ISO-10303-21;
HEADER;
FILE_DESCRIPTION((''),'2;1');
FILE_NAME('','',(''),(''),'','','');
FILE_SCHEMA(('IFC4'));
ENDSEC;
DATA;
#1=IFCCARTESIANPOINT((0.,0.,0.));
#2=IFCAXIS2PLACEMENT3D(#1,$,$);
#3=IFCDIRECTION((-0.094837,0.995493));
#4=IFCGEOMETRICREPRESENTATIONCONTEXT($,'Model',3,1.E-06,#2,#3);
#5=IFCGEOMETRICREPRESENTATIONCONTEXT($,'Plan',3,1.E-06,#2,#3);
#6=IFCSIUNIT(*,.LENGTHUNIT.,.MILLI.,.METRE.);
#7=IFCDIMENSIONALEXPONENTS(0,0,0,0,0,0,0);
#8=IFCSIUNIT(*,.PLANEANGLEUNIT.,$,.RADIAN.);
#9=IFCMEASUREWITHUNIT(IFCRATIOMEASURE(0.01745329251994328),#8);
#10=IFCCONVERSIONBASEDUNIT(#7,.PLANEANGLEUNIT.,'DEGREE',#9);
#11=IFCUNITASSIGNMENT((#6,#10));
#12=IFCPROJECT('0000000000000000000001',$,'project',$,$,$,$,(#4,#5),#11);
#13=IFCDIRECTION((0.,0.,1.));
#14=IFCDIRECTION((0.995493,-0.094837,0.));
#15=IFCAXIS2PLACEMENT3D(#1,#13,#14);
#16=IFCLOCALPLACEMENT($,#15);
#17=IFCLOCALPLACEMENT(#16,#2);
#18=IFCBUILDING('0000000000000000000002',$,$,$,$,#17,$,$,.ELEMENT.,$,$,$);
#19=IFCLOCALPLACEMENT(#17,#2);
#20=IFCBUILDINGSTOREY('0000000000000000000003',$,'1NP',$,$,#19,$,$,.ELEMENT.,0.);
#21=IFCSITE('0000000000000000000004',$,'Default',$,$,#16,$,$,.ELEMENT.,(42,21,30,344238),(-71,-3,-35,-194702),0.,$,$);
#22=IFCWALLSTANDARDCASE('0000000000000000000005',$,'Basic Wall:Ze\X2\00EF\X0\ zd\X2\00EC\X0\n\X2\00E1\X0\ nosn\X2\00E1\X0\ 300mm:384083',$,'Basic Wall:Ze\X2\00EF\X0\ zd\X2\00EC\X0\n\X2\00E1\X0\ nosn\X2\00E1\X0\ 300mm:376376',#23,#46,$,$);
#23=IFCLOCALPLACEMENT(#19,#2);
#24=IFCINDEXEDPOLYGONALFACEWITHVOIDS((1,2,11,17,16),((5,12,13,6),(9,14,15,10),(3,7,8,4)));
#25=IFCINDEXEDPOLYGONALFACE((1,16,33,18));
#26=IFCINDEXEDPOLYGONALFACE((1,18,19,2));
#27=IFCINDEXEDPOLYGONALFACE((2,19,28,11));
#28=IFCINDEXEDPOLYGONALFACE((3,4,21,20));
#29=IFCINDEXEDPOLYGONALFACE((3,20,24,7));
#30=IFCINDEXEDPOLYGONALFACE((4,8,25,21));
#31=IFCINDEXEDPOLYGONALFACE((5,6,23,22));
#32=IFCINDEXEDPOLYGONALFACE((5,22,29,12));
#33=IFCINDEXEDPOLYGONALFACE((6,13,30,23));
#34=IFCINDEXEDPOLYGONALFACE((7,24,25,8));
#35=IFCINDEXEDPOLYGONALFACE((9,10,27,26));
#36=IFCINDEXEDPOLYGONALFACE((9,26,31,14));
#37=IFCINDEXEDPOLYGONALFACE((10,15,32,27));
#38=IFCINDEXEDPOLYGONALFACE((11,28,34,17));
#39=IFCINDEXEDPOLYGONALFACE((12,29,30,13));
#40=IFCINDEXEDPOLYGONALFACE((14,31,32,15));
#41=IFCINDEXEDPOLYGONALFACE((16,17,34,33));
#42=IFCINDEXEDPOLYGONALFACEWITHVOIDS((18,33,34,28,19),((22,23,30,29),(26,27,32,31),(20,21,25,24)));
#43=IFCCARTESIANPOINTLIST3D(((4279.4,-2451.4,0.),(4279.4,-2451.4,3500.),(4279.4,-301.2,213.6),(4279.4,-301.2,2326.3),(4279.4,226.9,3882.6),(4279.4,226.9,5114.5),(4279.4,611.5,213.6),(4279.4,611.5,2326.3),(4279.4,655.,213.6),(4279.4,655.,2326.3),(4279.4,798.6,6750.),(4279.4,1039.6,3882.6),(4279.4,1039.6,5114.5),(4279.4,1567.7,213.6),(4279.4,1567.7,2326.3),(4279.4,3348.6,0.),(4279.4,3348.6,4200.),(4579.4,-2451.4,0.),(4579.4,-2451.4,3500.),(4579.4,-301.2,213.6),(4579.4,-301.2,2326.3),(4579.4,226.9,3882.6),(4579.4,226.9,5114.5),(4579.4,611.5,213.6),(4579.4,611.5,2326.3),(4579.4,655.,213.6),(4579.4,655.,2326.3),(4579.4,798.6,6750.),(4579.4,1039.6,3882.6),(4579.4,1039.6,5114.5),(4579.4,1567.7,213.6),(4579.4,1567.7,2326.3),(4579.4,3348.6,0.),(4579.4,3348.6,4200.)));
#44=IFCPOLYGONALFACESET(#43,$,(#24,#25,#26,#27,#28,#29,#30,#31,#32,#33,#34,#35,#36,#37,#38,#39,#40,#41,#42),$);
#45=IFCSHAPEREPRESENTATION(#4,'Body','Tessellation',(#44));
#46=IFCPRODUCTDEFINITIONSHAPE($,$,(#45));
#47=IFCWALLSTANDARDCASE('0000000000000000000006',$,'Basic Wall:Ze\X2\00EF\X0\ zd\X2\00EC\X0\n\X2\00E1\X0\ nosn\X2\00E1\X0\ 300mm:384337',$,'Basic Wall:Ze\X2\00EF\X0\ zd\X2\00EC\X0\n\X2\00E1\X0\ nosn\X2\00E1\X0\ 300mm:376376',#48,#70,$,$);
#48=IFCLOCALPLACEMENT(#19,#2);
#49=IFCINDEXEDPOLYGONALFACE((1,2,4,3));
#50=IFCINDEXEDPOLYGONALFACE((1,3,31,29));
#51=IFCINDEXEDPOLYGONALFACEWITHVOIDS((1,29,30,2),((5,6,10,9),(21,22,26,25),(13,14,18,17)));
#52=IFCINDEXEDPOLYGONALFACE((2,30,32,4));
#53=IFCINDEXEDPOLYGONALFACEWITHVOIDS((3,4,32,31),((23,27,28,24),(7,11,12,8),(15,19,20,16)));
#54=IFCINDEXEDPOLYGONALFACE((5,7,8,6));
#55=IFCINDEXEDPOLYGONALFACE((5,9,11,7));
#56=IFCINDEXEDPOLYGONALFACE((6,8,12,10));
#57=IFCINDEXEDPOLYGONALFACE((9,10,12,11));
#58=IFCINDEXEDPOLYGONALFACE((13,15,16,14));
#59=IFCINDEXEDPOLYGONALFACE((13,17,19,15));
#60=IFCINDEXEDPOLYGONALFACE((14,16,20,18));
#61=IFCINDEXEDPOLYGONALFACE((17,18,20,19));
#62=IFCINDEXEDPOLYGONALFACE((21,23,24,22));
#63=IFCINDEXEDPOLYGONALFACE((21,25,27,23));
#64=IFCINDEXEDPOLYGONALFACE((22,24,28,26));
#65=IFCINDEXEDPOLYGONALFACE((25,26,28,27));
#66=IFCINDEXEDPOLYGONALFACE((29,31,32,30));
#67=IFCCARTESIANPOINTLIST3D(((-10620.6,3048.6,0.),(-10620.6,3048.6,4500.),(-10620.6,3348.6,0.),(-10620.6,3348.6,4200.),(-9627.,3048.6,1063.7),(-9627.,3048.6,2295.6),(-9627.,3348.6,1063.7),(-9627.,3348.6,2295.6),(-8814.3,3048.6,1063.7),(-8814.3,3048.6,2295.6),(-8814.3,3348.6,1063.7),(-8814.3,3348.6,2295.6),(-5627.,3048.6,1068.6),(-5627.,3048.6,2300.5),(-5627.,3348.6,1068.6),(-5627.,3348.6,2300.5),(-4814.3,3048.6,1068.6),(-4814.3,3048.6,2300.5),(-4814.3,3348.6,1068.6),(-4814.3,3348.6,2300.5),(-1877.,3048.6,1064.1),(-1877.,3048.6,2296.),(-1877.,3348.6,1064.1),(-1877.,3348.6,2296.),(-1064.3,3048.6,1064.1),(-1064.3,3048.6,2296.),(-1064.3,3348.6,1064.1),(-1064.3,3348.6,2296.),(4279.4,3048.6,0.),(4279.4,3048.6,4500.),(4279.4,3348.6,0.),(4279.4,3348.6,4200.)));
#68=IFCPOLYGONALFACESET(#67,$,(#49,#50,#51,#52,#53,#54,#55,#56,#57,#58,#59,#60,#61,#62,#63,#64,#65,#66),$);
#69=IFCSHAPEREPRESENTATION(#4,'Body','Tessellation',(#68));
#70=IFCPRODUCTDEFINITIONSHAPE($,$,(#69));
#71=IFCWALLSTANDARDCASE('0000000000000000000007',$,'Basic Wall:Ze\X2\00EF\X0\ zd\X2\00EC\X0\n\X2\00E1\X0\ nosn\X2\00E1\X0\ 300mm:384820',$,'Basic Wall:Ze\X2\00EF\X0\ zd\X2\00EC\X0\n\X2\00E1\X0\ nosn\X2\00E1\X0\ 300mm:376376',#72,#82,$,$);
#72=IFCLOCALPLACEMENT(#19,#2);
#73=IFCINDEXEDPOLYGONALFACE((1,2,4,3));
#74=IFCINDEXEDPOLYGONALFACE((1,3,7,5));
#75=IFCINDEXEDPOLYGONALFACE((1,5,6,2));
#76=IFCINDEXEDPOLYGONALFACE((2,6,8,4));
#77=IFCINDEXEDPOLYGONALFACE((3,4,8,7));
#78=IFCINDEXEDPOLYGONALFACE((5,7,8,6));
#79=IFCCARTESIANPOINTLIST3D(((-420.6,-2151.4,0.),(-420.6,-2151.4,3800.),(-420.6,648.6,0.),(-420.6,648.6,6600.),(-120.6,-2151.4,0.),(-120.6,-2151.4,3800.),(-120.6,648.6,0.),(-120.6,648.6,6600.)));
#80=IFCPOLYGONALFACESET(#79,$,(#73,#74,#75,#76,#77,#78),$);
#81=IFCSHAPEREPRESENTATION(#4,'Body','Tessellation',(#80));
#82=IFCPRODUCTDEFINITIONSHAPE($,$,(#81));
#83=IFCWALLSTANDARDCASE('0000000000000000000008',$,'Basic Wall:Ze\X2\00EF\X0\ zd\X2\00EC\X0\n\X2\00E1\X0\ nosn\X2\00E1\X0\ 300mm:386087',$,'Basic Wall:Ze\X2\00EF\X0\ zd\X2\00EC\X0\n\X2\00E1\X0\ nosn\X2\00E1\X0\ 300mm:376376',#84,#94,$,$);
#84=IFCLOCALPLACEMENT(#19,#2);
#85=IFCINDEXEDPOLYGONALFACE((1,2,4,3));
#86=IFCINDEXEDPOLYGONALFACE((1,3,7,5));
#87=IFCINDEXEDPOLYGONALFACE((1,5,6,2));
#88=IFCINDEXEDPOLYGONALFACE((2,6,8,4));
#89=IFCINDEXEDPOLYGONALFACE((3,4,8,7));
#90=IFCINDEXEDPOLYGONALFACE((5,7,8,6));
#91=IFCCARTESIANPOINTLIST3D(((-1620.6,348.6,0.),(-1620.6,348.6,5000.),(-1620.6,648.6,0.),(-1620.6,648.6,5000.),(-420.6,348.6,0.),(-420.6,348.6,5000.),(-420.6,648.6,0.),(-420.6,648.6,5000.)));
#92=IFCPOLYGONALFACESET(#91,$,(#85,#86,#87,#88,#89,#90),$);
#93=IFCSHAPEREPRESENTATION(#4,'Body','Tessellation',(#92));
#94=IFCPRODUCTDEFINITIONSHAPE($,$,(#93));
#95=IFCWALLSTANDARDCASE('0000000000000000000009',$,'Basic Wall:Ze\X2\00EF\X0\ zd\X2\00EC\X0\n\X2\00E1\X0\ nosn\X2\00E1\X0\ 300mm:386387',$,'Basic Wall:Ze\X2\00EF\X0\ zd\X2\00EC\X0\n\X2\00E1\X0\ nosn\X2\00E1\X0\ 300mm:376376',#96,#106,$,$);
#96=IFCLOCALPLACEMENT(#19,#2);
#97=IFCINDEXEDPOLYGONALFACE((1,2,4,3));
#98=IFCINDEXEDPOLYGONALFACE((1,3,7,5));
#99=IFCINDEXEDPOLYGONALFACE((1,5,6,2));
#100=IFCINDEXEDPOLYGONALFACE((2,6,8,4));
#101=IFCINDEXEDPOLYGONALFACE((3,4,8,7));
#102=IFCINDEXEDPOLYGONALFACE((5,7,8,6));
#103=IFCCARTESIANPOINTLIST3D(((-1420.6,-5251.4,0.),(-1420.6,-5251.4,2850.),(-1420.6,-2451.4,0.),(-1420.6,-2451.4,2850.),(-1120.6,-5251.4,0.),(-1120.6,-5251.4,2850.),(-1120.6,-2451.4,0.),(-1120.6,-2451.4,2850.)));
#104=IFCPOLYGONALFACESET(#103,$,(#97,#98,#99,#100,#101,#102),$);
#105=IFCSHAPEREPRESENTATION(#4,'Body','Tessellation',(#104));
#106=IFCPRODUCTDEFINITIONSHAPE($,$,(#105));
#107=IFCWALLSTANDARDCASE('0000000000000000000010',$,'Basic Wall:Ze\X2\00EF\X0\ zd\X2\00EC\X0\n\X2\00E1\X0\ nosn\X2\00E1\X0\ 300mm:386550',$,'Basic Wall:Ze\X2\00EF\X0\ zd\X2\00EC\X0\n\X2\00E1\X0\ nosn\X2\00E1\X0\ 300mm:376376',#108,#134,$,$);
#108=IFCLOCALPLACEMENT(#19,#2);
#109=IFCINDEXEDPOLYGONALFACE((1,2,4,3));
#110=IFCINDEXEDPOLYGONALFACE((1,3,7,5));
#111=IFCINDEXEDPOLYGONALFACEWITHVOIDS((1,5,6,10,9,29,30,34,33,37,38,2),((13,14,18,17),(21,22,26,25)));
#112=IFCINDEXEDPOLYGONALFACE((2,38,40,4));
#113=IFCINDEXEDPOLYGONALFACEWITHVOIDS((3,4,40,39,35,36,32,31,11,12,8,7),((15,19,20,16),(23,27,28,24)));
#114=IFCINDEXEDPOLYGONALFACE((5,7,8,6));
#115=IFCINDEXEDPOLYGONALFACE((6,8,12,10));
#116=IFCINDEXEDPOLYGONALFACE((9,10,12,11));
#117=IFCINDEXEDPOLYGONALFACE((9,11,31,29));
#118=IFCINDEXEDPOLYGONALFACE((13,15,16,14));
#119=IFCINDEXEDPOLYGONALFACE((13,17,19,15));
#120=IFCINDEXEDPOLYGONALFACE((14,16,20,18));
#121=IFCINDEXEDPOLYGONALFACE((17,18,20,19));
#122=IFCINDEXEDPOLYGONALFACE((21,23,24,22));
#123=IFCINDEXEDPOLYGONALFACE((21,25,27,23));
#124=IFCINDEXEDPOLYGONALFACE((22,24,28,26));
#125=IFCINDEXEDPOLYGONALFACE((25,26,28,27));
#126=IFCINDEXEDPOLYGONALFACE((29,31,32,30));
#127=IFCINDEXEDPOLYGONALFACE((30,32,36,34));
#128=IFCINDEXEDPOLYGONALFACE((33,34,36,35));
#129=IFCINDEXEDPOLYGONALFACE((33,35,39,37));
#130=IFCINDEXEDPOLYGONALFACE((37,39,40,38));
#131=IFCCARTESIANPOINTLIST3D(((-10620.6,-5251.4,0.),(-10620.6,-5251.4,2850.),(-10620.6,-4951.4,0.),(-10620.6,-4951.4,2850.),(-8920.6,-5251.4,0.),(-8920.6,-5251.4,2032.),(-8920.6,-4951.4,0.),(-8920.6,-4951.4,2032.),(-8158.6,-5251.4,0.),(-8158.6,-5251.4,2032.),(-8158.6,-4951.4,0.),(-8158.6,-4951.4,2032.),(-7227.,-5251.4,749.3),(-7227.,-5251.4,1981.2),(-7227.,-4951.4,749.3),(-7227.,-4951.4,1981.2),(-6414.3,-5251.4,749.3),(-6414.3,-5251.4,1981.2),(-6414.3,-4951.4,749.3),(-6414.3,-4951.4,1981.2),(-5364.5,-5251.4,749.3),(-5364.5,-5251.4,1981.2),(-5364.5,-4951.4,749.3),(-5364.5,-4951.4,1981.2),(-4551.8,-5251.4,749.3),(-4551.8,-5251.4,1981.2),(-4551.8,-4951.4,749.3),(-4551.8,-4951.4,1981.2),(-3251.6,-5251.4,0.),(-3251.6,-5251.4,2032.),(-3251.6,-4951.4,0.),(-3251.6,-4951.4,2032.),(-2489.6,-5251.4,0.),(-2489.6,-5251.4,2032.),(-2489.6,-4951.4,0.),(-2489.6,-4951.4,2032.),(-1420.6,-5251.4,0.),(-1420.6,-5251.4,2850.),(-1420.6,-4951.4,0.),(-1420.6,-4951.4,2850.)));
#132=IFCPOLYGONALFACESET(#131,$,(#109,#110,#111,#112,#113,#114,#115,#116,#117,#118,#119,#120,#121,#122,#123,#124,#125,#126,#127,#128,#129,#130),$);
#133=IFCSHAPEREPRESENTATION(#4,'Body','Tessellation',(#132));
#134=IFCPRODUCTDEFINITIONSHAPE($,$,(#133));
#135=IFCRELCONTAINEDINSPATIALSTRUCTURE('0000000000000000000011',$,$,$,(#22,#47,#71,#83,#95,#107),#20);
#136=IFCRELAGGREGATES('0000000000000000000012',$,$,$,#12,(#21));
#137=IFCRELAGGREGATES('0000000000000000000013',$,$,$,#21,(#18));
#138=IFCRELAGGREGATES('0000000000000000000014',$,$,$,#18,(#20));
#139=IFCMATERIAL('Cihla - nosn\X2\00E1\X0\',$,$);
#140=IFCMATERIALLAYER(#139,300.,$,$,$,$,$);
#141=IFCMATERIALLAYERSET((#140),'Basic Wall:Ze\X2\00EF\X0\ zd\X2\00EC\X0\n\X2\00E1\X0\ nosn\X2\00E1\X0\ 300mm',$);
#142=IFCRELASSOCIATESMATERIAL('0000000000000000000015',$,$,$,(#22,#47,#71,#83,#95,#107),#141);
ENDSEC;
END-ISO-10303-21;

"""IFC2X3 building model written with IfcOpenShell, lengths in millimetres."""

from ifc_helpers import new_model, entity, si_unit, converted_unit, direction, frame, frame_2d, origin, place, context, project, spatial, polyline, rectangle, extrude, clip, bounded_halfspace, material, layer, layer_set, layer_usage, element, save


model = new_model("IFC2X3")

# Units and contexts
model_context = context("Model", 3, precision=1e-06, world=origin(), true_north=direction((-0.094837, 0.995493)))
plan_context = context("Plan", 3, precision=1e-06, world=origin(), true_north=direction((-0.094837, 0.995493)))
ifc_project = project(units=[si_unit("LENGTHUNIT", "METRE", prefix="MILLI"), converted_unit("PLANEANGLEUNIT", "DEGREE", entity("IfcRatioMeasure", 0.01745329251994328), si_unit("PLANEANGLEUNIT", "RADIAN"), dimensions=[0, 0, 0, 0, 0, 0, 0])], contexts=[model_context, plan_context])

# Site, building, storey
site_placement = place(None, frame((0.0, 0.0, 0.0), z_axis=(0.0, 0.0, 1.0), x_axis=(0.995493, -0.094837, 0.0)))
site = spatial("IfcSite", under=ifc_project, at=site_placement, Name="Default", CompositionType="ELEMENT", RefLatitude=(42, 21, 30, 344238), RefLongitude=(-71, -3, -35, -194702), RefElevation=0.0)
building_placement = place(site_placement, origin())
building = spatial("IfcBuilding", under=site, at=building_placement, CompositionType="ELEMENT")
storey_placement = place(building_placement, origin())
storey = spatial("IfcBuildingStorey", under=building, at=storey_placement, Name="1NP", CompositionType="ELEMENT", Elevation=0.0)

# Walls, openings
ifc_material_1 = material(Name="Cihla - nosná")
ifc_layer_1 = layer(ifc_material_1, 300.0)
ifc_layer_set_1 = layer_set([ifc_layer_1], Name="Basic Wall:Zeï zdìná nosná 300mm")
ifc_layer_usage_1 = layer_usage(ifc_layer_set_1, "AXIS2", "POSITIVE", -150.0)
wall_1_placement = place(storey_placement, frame((4429.4, -2451.4, 0.0), z_axis=(0.0, 0.0, 1.0), x_axis=(0.0, 1.0, 0.0)))
wall_1 = element("IfcWallStandardCase", 1, at=wall_1_placement, inside=storey, material=ifc_layer_usage_1, Name="Basic Wall:Zeï zdìná nosná 300mm:384083", ObjectType="Basic Wall:Zeï zdìná nosná 300mm:376376", context=model_context, shape_type="Clipping", body=[
    clip(clip(extrude(rectangle(XDim=5800.0, YDim=300.0, at=frame_2d((2900.0, 0.0), x_axis=(-1.0, 0.0))), origin(), (0.0, 0.0, 1.0), 6750.0), bounded_halfspace(frame((0.0, -150.0, 3500.0), z_axis=(-0.707107, 0.0, 0.707107), x_axis=(0.0, -1.0, 0.0)), False, frame((0.0, -150.0, 3500.0)), polyline([(0.0, 0.0), (3250.0, 0.0), (3250.0, 300.0), (300.0, 300.0), (0.0, 300.0), (0.0, 0.0)]))), bounded_halfspace(frame((3250.0, -150.0, 6750.0), z_axis=(0.707107, 0.0, 0.707107), x_axis=(0.0, 1.0, 0.0)), False, frame((3250.0, -150.0, 6750.0)), polyline([(0.0, 0.0), (2550.0, 0.0), (2550.0, 300.0), (2250.0, 300.0), (0.0, 300.0), (0.0, 0.0)]))),
])
opening_1_placement = place(wall_1_placement, frame((4019.1, 150.0, 213.6)))
element("IfcOpeningElement", 2, at=opening_1_placement, cuts=wall_1, ObjectType="Opening", context=model_context, shape_type="SweptSolid", body=[
    extrude(rectangle(XDim=2112.7, YDim=912.7, at=frame_2d((1056.3, 456.3), x_axis=(-1.0, 0.0))), frame((0.0, 0.0, 0.0), z_axis=(0.0, -1.0, 0.0), x_axis=(0.0, 0.0, 1.0)), (0.0, 0.0, 1.0), 300.0),
])
opening_2_placement = place(wall_1_placement, frame((3062.9, 150.0, 213.6)))
element("IfcOpeningElement", 3, at=opening_2_placement, cuts=wall_1, ObjectType="Opening", context=model_context, shape_type="SweptSolid", body=[
    extrude(rectangle(XDim=2112.7, YDim=912.7, at=frame_2d((1056.3, 456.3), x_axis=(-1.0, 0.0))), frame((0.0, 0.0, 0.0), z_axis=(0.0, -1.0, 0.0), x_axis=(0.0, 0.0, 1.0)), (0.0, 0.0, 1.0), 300.0),
])
opening_3_placement = place(wall_1_placement, frame((3491.0, 150.0, 3882.6)))
element("IfcOpeningElement", 4, at=opening_3_placement, cuts=wall_1, ObjectType="Opening", context=model_context, shape_type="SweptSolid", body=[
    extrude(rectangle(XDim=1231.9, YDim=812.7, at=frame_2d((615.9, 406.4), x_axis=(-1.0, 0.0))), frame((0.0, 0.0, 0.0), z_axis=(0.0, -1.0, 0.0), x_axis=(0.0, 0.0, 1.0)), (0.0, 0.0, 1.0), 300.0),
])
ifc_layer_usage_2 = layer_usage(ifc_layer_set_1, "AXIS2", "POSITIVE", -150.0)
wall_2_placement = place(storey_placement, frame((4279.4, 3198.6, 0.0), z_axis=(0.0, 0.0, 1.0), x_axis=(-1.0, 0.0, 0.0)))
wall_2 = element("IfcWallStandardCase", 5, at=wall_2_placement, inside=storey, material=ifc_layer_usage_2, Name="Basic Wall:Zeï zdìná nosná 300mm:384337", ObjectType="Basic Wall:Zeï zdìná nosná 300mm:376376", context=model_context, shape_type="Clipping", body=[
    clip(extrude(rectangle(XDim=14900.0, YDim=300.0, at=frame_2d((7450.0, 0.0), x_axis=(-1.0, 0.0))), origin(), (0.0, 0.0, 1.0), 4500.0), bounded_halfspace(frame((0.0, -150.0, 4200.0), z_axis=(0.0, -0.707107, 0.707107), x_axis=(1.0, 0.0, 0.0)), False, frame((0.0, -150.0, 4200.0)), polyline([(0.0, 0.0), (14900.0, 0.0), (14900.0, 300.0), (14600.0, 300.0), (0.0, 300.0), (0.0, 0.0)]))),
])
opening_4_placement = place(wall_2_placement, frame((6156.4, 150.0, 1064.1)))
element("IfcOpeningElement", 6, at=opening_4_placement, cuts=wall_2, ObjectType="Opening", context=model_context, shape_type="SweptSolid", body=[
    extrude(rectangle(XDim=1231.9, YDim=812.7, at=frame_2d((615.9, 406.4), x_axis=(-1.0, 0.0))), frame((0.0, 0.0, 0.0), z_axis=(0.0, -1.0, 0.0), x_axis=(0.0, 0.0, 1.0)), (0.0, 0.0, 1.0), 300.0),
])
opening_5_placement = place(wall_2_placement, frame((9906.4, 150.0, 1068.6)))
element("IfcOpeningElement", 7, at=opening_5_placement, cuts=wall_2, ObjectType="Opening", context=model_context, shape_type="SweptSolid", body=[
    extrude(rectangle(XDim=1231.9, YDim=812.7, at=frame_2d((615.9, 406.3), x_axis=(-1.0, 0.0))), frame((0.0, 0.0, 0.0), z_axis=(0.0, -1.0, 0.0), x_axis=(0.0, 0.0, 1.0)), (0.0, 0.0, 1.0), 300.0),
])
opening_6_placement = place(wall_2_placement, frame((13906.4, 150.0, 1063.7)))
element("IfcOpeningElement", 8, at=opening_6_placement, cuts=wall_2, ObjectType="Opening", context=model_context, shape_type="SweptSolid", body=[
    extrude(rectangle(XDim=1231.9, YDim=812.7, at=frame_2d((615.9, 406.3), x_axis=(-1.0, 0.0))), frame((0.0, 0.0, 0.0), z_axis=(0.0, -1.0, 0.0), x_axis=(0.0, 0.0, 1.0)), (0.0, 0.0, 1.0), 300.0),
])

# Walls
ifc_layer_usage_3 = layer_usage(ifc_layer_set_1, "AXIS2", "POSITIVE", -150.0)
wall_3_placement = place(storey_placement, frame((-270.6, -2151.4, 0.0), z_axis=(0.0, 0.0, 1.0), x_axis=(0.0, 1.0, 0.0)))
element("IfcWallStandardCase", 9, at=wall_3_placement, inside=storey, material=ifc_layer_usage_3, Name="Basic Wall:Zeï zdìná nosná 300mm:384820", ObjectType="Basic Wall:Zeï zdìná nosná 300mm:376376", context=model_context, shape_type="Clipping", body=[
    clip(extrude(rectangle(XDim=2800.0, YDim=300.0, at=frame_2d((1400.0, 0.0), x_axis=(-1.0, 0.0))), origin(), (0.0, 0.0, 1.0), 6600.0), bounded_halfspace(frame((0.0, -150.0, 3800.0), z_axis=(-0.707107, 0.0, 0.707107), x_axis=(0.0, -1.0, 0.0)), False, frame((0.0, -150.0, 3800.0)), polyline([(0.0, 0.0), (2800.0, 0.0), (2800.0, 300.0), (0.0, 300.0), (0.0, 0.0)]))),
])
ifc_layer_usage_4 = layer_usage(ifc_layer_set_1, "AXIS2", "POSITIVE", -150.0)
wall_4_placement = place(storey_placement, frame((-420.6, 498.6, 0.0), z_axis=(0.0, 0.0, 1.0), x_axis=(-1.0, 0.0, 0.0)))
element("IfcWallStandardCase", 10, at=wall_4_placement, inside=storey, material=ifc_layer_usage_4, Name="Basic Wall:Zeï zdìná nosná 300mm:386087", ObjectType="Basic Wall:Zeï zdìná nosná 300mm:376376", context=model_context, shape_type="SweptSolid", body=[
    extrude(rectangle(XDim=1200.0, YDim=300.0, at=frame_2d((600.0, 0.0), x_axis=(-1.0, 0.0))), origin(), (0.0, 0.0, 1.0), 5000.0),
])
ifc_layer_usage_5 = layer_usage(ifc_layer_set_1, "AXIS2", "POSITIVE", -150.0)
wall_5_placement = place(storey_placement, frame((-1270.6, -2451.4, 0.0), z_axis=(0.0, 0.0, 1.0), x_axis=(0.0, -1.0, 0.0)))
element("IfcWallStandardCase", 11, at=wall_5_placement, inside=storey, material=ifc_layer_usage_5, Name="Basic Wall:Zeï zdìná nosná 300mm:386387", ObjectType="Basic Wall:Zeï zdìná nosná 300mm:376376", context=model_context, shape_type="Clipping", body=[
    clip(extrude(rectangle(XDim=2800.0, YDim=300.0, at=frame_2d((1400.0, 0.0), x_axis=(-1.0, 0.0))), origin(), (0.0, 0.0, 1.0), 3000.0), bounded_halfspace(frame((0.0, -150.0, 2850.0), z_axis=(0.0, 0.0, -1.0), x_axis=(1.0, 0.0, 0.0)), True, frame((0.0, -150.0, 2850.0)), polyline([(0.0, 0.0), (2500.0, 0.0), (2800.0, 0.0), (2800.0, 300.0), (0.0, 300.0), (0.0, 0.0)]))),
])

# Wall, openings
ifc_layer_usage_6 = layer_usage(ifc_layer_set_1, "AXIS2", "NEGATIVE", 150.0)
wall_6_placement = place(storey_placement, frame((-1420.6, -5101.4, 0.0), z_axis=(0.0, 0.0, 1.0), x_axis=(-1.0, 0.0, 0.0)))
wall_6 = element("IfcWallStandardCase", 12, at=wall_6_placement, inside=storey, material=ifc_layer_usage_6, Name="Basic Wall:Zeï zdìná nosná 300mm:386550", ObjectType="Basic Wall:Zeï zdìná nosná 300mm:376376", context=model_context, shape_type="Clipping", body=[
    clip(extrude(rectangle(XDim=9200.0, YDim=300.0, at=frame_2d((4600.0, 0.0), x_axis=(-1.0, 0.0))), origin(), (0.0, 0.0, 1.0), 3000.0), bounded_halfspace(frame((0.0, -150.0, 2850.0), z_axis=(0.0, 0.0, -1.0), x_axis=(0.0, 1.0, 0.0)), True, frame((0.0, -150.0, 2850.0)), polyline([(0.0, 0.0), (8900.0, 0.0), (9200.0, 0.0), (9200.0, 300.0), (0.0, 300.0), (0.0, 0.0)]))),
])
opening_7_placement = place(wall_6_placement, frame((1831.0, 150.0, 0.0)))
element("IfcOpeningElement", 13, at=opening_7_placement, cuts=wall_6, ObjectType="Opening", context=model_context, shape_type="SweptSolid", body=[
    extrude(rectangle(XDim=2032.0, YDim=762.0, at=frame_2d((1016.0, 381.0), x_axis=(1.0, 0.0))), frame((0.0, 0.0, 0.0), z_axis=(0.0, -1.0, 0.0), x_axis=(0.0, 0.0, 1.0)), (0.0, 0.0, 1.0), 300.0),
])
opening_8_placement = place(wall_6_placement, frame((3131.2, -150.0, 749.3)))
element("IfcOpeningElement", 14, at=opening_8_placement, cuts=wall_6, ObjectType="Opening", context=model_context, shape_type="SweptSolid", body=[
    extrude(rectangle(XDim=1231.9, YDim=812.7, at=frame_2d((615.9, 406.3), x_axis=(-1.0, 0.0))), frame((0.0, 0.0, 0.0), z_axis=(0.0, 1.0, 0.0), x_axis=(0.0, 0.0, 1.0)), (0.0, 0.0, 1.0), 300.0),
])
opening_9_placement = place(wall_6_placement, frame((4993.6, -150.0, 749.3)))
element("IfcOpeningElement", 15, at=opening_9_placement, cuts=wall_6, ObjectType="Opening", context=model_context, shape_type="SweptSolid", body=[
    extrude(rectangle(XDim=1231.9, YDim=812.7, at=frame_2d((615.9, 406.3), x_axis=(-1.0, 0.0))), frame((0.0, 0.0, 0.0), z_axis=(0.0, 1.0, 0.0), x_axis=(0.0, 0.0, 1.0)), (0.0, 0.0, 1.0), 300.0),
])
opening_10_placement = place(wall_6_placement, frame((7500.0, 150.0, 0.0)))
element("IfcOpeningElement", 16, at=opening_10_placement, cuts=wall_6, ObjectType="Opening", context=model_context, shape_type="SweptSolid", body=[
    extrude(rectangle(XDim=2032.0, YDim=762.0, at=frame_2d((1016.0, 381.0), x_axis=(1.0, 0.0))), frame((0.0, 0.0, 0.0), z_axis=(0.0, -1.0, 0.0), x_axis=(0.0, 0.0, 1.0)), (0.0, 0.0, 1.0), 300.0),
])

save(model, "model.ifc")
